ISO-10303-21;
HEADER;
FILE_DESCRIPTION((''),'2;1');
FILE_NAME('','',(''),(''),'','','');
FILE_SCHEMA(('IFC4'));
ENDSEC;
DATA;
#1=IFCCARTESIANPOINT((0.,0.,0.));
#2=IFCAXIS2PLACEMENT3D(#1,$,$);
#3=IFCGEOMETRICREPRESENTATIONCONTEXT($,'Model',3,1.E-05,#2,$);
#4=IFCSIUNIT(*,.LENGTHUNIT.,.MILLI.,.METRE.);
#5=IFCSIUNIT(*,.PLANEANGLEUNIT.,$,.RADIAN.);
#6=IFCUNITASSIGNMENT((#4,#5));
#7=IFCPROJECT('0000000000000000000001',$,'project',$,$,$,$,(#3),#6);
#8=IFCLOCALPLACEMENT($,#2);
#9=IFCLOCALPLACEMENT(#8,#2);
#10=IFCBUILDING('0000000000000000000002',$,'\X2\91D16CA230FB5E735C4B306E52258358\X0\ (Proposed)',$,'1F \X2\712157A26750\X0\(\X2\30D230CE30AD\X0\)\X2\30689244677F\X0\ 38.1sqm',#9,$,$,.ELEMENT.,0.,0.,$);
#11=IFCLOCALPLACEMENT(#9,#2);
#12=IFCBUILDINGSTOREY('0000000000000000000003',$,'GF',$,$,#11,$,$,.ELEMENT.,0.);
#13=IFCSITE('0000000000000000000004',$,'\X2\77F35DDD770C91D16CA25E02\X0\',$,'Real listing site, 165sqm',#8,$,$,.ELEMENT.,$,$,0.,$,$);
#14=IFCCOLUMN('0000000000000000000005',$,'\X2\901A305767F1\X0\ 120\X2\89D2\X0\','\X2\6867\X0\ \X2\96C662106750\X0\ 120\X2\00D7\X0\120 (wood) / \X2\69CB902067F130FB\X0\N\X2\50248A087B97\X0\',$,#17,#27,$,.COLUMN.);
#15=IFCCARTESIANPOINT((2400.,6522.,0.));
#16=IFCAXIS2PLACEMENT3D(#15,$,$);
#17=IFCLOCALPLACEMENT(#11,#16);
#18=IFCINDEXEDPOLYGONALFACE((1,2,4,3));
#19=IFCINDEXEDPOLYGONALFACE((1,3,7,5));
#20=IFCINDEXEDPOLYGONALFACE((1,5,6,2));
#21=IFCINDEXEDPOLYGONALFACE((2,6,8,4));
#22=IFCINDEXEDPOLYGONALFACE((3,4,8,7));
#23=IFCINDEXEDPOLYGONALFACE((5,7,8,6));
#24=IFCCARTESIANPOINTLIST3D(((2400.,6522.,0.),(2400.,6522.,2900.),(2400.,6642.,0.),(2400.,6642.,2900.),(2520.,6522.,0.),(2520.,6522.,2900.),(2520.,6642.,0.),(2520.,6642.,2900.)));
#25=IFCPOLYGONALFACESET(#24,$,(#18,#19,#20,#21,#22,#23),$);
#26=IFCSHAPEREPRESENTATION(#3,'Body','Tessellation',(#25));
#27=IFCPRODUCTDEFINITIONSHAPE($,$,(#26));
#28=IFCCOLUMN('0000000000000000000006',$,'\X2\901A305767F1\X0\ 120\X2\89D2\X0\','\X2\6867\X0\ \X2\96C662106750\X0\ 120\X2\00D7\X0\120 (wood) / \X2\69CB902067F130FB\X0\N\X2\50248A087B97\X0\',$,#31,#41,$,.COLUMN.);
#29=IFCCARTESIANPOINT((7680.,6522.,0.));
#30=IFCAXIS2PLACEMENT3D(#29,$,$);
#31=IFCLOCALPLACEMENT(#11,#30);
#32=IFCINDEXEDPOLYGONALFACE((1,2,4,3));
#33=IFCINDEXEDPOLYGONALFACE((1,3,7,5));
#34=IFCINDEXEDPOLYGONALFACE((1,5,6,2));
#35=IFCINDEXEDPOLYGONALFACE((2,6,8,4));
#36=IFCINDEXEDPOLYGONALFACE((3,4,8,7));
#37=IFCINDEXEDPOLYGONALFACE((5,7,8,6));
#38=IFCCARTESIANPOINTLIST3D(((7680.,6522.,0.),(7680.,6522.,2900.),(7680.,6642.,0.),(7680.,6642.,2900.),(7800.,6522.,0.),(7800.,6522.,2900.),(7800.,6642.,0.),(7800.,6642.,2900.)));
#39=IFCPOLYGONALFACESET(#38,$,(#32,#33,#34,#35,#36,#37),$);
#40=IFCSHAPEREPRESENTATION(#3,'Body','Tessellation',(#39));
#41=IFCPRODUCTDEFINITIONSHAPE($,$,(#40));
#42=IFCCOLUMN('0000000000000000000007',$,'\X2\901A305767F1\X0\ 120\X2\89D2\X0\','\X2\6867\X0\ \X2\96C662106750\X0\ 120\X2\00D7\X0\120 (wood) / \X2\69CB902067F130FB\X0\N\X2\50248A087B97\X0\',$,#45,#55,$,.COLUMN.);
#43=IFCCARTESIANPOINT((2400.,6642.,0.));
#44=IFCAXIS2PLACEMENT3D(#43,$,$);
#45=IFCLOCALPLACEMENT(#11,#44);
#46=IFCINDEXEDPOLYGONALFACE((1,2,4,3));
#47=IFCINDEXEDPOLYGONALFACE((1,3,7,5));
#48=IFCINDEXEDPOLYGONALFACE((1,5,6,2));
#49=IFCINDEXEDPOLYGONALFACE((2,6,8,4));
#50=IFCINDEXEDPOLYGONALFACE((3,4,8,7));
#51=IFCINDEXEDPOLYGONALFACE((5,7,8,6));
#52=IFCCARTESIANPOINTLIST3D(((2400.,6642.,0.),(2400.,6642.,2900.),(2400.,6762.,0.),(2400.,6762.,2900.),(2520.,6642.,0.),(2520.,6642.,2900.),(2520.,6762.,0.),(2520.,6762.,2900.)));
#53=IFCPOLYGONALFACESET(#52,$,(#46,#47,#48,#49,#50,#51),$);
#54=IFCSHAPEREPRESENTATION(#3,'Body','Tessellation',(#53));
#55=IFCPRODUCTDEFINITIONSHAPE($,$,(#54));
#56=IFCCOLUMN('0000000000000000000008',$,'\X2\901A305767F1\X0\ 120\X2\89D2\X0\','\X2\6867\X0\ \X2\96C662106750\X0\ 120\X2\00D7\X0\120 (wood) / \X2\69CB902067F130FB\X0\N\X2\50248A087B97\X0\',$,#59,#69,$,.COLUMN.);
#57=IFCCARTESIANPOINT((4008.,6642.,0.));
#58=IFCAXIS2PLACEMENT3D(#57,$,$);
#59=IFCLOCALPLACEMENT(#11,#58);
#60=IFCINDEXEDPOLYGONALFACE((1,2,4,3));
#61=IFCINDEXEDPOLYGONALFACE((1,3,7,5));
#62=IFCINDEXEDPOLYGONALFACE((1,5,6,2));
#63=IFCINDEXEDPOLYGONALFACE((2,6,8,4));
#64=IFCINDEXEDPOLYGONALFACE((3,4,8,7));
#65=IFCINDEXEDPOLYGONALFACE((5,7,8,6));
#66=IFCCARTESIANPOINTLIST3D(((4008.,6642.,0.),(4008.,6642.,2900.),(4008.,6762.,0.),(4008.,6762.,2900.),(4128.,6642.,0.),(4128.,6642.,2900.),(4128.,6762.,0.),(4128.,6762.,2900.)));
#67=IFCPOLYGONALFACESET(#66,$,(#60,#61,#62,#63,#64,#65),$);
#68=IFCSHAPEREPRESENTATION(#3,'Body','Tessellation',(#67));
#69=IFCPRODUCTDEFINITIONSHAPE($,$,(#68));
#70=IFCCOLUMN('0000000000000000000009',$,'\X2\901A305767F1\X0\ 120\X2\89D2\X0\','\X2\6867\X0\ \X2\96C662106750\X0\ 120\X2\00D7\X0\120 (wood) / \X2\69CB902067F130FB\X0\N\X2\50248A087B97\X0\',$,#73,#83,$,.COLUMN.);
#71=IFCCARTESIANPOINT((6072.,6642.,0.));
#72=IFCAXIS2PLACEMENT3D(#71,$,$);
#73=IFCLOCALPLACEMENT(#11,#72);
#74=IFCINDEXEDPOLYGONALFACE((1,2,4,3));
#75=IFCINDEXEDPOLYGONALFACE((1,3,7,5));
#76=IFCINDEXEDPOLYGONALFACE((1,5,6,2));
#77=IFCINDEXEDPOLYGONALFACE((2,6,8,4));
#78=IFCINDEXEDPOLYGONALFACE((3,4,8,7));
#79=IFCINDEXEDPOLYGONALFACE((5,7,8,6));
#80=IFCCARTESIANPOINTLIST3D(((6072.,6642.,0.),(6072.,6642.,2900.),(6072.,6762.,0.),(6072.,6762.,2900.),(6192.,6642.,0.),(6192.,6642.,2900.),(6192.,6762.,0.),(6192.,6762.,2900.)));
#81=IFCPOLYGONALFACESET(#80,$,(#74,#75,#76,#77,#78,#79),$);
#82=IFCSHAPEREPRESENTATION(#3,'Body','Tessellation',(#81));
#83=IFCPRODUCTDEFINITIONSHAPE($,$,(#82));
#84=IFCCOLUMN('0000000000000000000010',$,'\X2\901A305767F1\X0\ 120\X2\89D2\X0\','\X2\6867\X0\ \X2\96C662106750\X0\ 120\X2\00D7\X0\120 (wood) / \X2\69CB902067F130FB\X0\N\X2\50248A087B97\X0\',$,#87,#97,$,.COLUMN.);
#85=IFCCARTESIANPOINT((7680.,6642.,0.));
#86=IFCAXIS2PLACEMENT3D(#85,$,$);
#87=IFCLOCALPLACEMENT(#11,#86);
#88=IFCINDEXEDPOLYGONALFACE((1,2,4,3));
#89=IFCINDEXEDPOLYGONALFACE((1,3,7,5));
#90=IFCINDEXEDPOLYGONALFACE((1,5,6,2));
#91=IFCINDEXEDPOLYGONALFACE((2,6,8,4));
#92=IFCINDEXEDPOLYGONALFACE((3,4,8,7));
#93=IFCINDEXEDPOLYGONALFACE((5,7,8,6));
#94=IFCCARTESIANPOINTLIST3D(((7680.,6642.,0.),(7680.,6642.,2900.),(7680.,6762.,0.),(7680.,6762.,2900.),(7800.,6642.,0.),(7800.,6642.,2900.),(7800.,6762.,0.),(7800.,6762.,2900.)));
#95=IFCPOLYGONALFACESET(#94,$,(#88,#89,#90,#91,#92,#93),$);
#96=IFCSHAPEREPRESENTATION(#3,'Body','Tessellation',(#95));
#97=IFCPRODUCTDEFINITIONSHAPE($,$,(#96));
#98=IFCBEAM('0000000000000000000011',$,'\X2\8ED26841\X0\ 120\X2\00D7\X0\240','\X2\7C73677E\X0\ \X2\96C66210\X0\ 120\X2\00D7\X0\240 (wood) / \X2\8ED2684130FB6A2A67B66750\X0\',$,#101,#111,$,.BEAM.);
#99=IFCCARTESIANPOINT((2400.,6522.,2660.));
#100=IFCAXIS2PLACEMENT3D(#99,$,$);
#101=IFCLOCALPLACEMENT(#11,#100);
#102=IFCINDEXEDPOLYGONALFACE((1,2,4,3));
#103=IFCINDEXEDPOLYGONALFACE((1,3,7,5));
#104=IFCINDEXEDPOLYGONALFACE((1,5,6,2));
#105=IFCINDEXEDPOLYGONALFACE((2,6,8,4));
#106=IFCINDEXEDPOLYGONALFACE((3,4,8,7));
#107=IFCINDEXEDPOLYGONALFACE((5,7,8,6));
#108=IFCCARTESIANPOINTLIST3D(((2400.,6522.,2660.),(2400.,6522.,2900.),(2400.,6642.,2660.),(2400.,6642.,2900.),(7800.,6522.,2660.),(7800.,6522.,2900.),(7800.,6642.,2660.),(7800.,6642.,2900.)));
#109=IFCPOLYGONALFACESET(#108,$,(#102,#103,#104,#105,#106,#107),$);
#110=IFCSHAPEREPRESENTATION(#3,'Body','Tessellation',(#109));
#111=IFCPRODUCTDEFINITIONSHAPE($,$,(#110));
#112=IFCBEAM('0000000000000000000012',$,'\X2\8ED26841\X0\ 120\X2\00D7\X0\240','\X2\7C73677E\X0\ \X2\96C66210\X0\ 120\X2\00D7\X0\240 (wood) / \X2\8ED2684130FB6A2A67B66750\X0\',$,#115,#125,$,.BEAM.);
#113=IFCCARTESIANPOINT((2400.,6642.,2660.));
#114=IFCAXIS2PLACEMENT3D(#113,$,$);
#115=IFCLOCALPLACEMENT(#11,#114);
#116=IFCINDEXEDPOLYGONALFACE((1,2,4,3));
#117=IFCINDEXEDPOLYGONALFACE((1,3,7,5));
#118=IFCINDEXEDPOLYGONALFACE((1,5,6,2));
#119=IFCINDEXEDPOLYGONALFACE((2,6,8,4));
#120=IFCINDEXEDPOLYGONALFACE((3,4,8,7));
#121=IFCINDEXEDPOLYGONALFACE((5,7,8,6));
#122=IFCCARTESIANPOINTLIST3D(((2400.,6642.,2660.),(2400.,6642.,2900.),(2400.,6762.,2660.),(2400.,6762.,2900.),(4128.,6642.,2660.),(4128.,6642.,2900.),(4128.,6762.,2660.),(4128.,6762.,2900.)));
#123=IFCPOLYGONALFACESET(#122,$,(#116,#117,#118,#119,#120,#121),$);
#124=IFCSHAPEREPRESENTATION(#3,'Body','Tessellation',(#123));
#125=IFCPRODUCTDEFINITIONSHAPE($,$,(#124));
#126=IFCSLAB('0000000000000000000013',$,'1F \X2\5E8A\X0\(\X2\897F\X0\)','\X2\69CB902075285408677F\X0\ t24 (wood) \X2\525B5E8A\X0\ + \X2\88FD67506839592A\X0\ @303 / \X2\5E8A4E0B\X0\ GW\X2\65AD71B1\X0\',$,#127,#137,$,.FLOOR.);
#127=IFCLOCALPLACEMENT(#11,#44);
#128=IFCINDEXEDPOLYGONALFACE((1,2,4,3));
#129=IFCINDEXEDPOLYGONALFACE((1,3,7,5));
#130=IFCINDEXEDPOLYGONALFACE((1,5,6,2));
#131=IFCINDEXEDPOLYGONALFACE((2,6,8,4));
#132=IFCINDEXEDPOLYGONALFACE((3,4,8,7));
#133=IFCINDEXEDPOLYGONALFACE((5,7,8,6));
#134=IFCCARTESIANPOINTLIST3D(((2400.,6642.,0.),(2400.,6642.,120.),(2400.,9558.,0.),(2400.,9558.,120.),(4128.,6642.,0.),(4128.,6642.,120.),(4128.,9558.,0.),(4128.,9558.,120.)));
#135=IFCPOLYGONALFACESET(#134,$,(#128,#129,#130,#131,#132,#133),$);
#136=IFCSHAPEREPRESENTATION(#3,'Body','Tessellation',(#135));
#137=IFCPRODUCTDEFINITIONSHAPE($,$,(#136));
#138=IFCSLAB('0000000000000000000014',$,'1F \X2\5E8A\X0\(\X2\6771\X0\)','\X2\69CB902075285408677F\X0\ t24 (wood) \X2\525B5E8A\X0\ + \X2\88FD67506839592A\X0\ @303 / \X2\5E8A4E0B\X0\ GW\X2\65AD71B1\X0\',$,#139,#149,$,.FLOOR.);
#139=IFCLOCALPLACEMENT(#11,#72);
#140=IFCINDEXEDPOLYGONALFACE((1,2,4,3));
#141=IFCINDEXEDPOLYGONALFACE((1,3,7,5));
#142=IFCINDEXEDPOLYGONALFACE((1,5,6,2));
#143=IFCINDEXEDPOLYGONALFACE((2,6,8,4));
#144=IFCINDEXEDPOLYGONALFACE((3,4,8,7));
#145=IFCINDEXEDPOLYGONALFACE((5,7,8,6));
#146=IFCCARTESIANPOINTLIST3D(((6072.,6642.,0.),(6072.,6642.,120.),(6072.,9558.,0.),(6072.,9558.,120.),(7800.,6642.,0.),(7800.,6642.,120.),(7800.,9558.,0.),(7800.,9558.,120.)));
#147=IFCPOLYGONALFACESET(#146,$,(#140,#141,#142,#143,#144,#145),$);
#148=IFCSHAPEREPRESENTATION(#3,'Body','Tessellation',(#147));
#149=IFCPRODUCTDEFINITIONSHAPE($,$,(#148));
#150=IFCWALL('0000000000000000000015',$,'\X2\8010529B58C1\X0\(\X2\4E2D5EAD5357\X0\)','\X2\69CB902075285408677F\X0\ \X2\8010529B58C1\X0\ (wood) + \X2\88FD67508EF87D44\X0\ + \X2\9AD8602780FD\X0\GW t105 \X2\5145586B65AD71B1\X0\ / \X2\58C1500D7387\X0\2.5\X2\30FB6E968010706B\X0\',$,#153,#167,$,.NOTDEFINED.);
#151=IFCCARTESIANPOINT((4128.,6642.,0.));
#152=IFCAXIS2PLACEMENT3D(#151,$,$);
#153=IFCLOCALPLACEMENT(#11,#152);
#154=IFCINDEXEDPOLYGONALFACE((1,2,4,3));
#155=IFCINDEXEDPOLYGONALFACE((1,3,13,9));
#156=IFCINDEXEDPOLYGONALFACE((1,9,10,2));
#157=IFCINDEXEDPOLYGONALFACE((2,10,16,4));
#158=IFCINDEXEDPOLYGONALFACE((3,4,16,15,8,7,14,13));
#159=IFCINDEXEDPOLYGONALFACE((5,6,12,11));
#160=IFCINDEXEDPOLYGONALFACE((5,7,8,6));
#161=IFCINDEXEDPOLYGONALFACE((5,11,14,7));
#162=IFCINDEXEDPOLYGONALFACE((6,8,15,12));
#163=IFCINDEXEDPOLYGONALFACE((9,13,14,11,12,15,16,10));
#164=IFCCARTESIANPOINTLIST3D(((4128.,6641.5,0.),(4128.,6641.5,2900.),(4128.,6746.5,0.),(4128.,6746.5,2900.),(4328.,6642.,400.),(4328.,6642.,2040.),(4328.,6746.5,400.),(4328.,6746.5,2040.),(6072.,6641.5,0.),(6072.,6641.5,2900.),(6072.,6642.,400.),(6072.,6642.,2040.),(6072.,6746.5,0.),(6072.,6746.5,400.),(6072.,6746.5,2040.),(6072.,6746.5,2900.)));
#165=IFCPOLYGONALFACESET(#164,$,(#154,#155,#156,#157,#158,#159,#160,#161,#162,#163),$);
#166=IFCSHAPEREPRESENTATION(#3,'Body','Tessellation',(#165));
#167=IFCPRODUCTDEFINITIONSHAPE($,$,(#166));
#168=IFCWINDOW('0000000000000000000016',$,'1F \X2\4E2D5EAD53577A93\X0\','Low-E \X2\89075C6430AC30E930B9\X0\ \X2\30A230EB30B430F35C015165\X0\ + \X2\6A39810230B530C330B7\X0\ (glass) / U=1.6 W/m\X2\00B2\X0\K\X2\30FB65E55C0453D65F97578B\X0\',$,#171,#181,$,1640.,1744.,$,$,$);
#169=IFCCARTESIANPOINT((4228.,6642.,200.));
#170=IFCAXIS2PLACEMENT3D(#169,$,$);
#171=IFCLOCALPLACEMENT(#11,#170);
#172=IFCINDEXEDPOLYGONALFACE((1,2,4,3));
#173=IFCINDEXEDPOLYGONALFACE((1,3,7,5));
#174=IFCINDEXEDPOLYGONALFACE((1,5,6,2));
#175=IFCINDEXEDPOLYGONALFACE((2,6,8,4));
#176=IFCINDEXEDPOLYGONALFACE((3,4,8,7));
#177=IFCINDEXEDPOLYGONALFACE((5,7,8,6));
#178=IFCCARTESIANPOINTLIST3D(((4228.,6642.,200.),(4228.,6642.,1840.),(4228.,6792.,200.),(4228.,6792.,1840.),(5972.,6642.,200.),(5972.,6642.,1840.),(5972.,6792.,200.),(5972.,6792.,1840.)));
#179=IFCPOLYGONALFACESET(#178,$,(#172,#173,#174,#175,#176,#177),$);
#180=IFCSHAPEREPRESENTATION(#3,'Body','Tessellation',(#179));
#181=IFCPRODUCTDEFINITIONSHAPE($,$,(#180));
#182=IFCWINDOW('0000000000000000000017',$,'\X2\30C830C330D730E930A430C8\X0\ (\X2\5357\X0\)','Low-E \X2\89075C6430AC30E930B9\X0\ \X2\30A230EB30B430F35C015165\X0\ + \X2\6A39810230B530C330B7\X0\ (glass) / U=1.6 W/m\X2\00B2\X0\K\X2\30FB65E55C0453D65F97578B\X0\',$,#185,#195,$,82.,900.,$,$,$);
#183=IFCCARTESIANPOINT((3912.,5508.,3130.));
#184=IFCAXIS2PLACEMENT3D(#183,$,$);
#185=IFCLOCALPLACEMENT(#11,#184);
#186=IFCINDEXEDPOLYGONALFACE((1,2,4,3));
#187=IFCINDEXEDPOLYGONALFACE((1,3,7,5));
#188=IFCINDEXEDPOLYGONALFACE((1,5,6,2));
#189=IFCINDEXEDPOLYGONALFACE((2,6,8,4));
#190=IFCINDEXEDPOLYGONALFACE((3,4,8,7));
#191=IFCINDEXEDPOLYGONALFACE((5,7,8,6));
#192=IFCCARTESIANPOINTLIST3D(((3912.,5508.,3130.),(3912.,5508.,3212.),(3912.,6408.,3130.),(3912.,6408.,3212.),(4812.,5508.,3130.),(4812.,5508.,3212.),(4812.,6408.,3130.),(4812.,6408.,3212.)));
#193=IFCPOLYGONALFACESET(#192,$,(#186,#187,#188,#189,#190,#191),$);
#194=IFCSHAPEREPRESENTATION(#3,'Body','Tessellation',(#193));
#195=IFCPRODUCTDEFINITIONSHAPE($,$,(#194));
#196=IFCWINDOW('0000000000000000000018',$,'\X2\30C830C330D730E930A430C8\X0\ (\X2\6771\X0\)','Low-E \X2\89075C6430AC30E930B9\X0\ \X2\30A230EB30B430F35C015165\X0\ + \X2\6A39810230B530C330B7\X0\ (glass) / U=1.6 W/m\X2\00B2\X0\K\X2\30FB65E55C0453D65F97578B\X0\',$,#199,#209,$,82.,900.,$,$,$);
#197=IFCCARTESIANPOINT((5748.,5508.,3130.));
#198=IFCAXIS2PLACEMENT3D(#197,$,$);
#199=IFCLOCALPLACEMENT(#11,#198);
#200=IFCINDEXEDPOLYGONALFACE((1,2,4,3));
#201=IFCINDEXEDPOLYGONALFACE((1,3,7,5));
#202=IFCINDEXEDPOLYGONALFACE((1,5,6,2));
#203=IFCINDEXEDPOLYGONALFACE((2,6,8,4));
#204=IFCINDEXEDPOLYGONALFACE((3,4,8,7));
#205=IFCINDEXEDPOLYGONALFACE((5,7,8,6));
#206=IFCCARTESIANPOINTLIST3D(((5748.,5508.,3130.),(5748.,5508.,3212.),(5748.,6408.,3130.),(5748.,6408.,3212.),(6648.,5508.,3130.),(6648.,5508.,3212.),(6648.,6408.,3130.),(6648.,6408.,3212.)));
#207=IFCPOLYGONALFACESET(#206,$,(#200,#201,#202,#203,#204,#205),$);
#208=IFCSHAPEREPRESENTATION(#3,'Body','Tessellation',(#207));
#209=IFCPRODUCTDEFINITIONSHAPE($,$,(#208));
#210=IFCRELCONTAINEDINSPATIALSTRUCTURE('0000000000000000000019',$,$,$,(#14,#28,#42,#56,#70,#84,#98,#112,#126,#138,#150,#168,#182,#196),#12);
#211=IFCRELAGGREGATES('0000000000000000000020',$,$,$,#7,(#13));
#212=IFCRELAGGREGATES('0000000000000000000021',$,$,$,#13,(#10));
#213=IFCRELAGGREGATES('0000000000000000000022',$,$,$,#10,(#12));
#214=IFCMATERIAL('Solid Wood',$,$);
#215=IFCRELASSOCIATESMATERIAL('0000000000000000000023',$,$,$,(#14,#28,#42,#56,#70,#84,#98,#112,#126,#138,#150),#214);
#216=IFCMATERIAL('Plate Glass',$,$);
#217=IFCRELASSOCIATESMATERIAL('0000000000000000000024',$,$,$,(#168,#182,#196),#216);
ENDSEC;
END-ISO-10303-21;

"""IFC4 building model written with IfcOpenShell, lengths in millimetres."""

from ifc_helpers import new_model, si_unit, frame, frame_2d, origin, place, context, project, spatial, rectangle, extrude, material, element, fill, save


model = new_model("IFC4")

# Units and contexts
model_context = context("Model", 3, precision=1e-05, world=origin())
ifc_project = project(units=[si_unit("LENGTHUNIT", "METRE", prefix="MILLI"), si_unit("PLANEANGLEUNIT", "RADIAN")], contexts=[model_context])

# Site, building, storey
site_placement = place(None, origin())
site = spatial("IfcSite", under=ifc_project, at=site_placement, Name="石川県金沢市", ObjectType="Real listing site, 165sqm", CompositionType="ELEMENT", RefElevation=0.0)
building_placement = place(site_placement, origin())
building = spatial("IfcBuilding", under=site, at=building_placement, Name="金沢・平屋の別荘 (Proposed)", ObjectType="1F 無垢材(ヒノキ)と鉄板 38.1sqm", CompositionType="ELEMENT", ElevationOfRefHeight=0.0, ElevationOfTerrain=0.0)
storey_placement = place(building_placement, origin())
storey = spatial("IfcBuildingStorey", under=building, at=storey_placement, Name="GF", CompositionType="ELEMENT", Elevation=0.0)

# Columns
ifc_material_1 = material(Name="Solid Wood")
column_1_placement = place(storey_placement, frame((2400.0, 6522.0, 0.0)))
element("IfcColumn", 1, at=column_1_placement, inside=storey, material=ifc_material_1, Name="通し柱 120角", Description="桧 集成材 120×120 (wood) / 構造柱・N値計算", PredefinedType="COLUMN", context=model_context, shape_type="SweptSolid", body=[
    extrude(rectangle(XDim=120.0, YDim=120.0, at=frame_2d((60.0, 60.0))), frame((2400.0, 6522.0, 0.0)), (0.0, 0.0, 1.0), 2900.0),
])
column_2_placement = place(storey_placement, frame((7680.0, 6522.0, 0.0)))
element("IfcColumn", 2, at=column_2_placement, inside=storey, material=ifc_material_1, Name="通し柱 120角", Description="桧 集成材 120×120 (wood) / 構造柱・N値計算", PredefinedType="COLUMN", context=model_context, shape_type="SweptSolid", body=[
    extrude(rectangle(XDim=120.0, YDim=120.0, at=frame_2d((60.0, 60.0))), frame((7680.0, 6522.0, 0.0)), (0.0, 0.0, 1.0), 2900.0),
])
column_3_placement = place(storey_placement, frame((2400.0, 6642.0, 0.0)))
element("IfcColumn", 3, at=column_3_placement, inside=storey, material=ifc_material_1, Name="通し柱 120角", Description="桧 集成材 120×120 (wood) / 構造柱・N値計算", PredefinedType="COLUMN", context=model_context, shape_type="SweptSolid", body=[
    extrude(rectangle(XDim=120.0, YDim=120.0, at=frame_2d((60.0, 60.0))), frame((2400.0, 6642.0, 0.0)), (0.0, 0.0, 1.0), 2900.0),
])
column_4_placement = place(storey_placement, frame((4008.0, 6642.0, 0.0)))
element("IfcColumn", 4, at=column_4_placement, inside=storey, material=ifc_material_1, Name="通し柱 120角", Description="桧 集成材 120×120 (wood) / 構造柱・N値計算", PredefinedType="COLUMN", context=model_context, shape_type="SweptSolid", body=[
    extrude(rectangle(XDim=120.0, YDim=120.0, at=frame_2d((60.0, 60.0))), frame((4008.0, 6642.0, 0.0)), (0.0, 0.0, 1.0), 2900.0),
])
column_5_placement = place(storey_placement, frame((6072.0, 6642.0, 0.0)))
element("IfcColumn", 5, at=column_5_placement, inside=storey, material=ifc_material_1, Name="通し柱 120角", Description="桧 集成材 120×120 (wood) / 構造柱・N値計算", PredefinedType="COLUMN", context=model_context, shape_type="SweptSolid", body=[
    extrude(rectangle(XDim=120.0, YDim=120.0, at=frame_2d((60.0, 60.0))), frame((6072.0, 6642.0, 0.0)), (0.0, 0.0, 1.0), 2900.0),
])
column_6_placement = place(storey_placement, frame((7680.0, 6642.0, 0.0)))
element("IfcColumn", 6, at=column_6_placement, inside=storey, material=ifc_material_1, Name="通し柱 120角", Description="桧 集成材 120×120 (wood) / 構造柱・N値計算", PredefinedType="COLUMN", context=model_context, shape_type="SweptSolid", body=[
    extrude(rectangle(XDim=120.0, YDim=120.0, at=frame_2d((60.0, 60.0))), frame((7680.0, 6642.0, 0.0)), (0.0, 0.0, 1.0), 2900.0),
])

# Beams
beam_1_placement = place(storey_placement, frame((2400.0, 6522.0, 2660.0)))
element("IfcBeam", 7, at=beam_1_placement, inside=storey, material=ifc_material_1, Name="軒桁 120×240", Description="米松 集成 120×240 (wood) / 軒桁・横架材", PredefinedType="BEAM", context=model_context, shape_type="SweptSolid", body=[
    extrude(rectangle(XDim=5400.0, YDim=120.0, at=frame_2d((2700.0, 60.0))), frame((2400.0, 6522.0, 2660.0)), (0.0, 0.0, 1.0), 240.0),
])
beam_2_placement = place(storey_placement, frame((2400.0, 6642.0, 2660.0)))
element("IfcBeam", 8, at=beam_2_placement, inside=storey, material=ifc_material_1, Name="軒桁 120×240", Description="米松 集成 120×240 (wood) / 軒桁・横架材", PredefinedType="BEAM", context=model_context, shape_type="SweptSolid", body=[
    extrude(rectangle(XDim=1728.0, YDim=120.0, at=frame_2d((864.0, 60.0))), frame((2400.0, 6642.0, 2660.0)), (0.0, 0.0, 1.0), 240.0),
])

# Slabs
slab_1_placement = place(storey_placement, frame((2400.0, 6642.0, 0.0)))
element("IfcSlab", 9, at=slab_1_placement, inside=storey, material=ifc_material_1, Name="1F 床(西)", Description="構造用合板 t24 (wood) 剛床 + 製材根太 @303 / 床下 GW断熱", PredefinedType="FLOOR", context=model_context, shape_type="SweptSolid", body=[
    extrude(rectangle(XDim=1728.0, YDim=2916.0, at=frame_2d((864.0, 1458.0))), frame((2400.0, 6642.0, 0.0)), (0.0, 0.0, 1.0), 120.0),
])
slab_2_placement = place(storey_placement, frame((6072.0, 6642.0, 0.0)))
element("IfcSlab", 10, at=slab_2_placement, inside=storey, material=ifc_material_1, Name="1F 床(東)", Description="構造用合板 t24 (wood) 剛床 + 製材根太 @303 / 床下 GW断熱", PredefinedType="FLOOR", context=model_context, shape_type="SweptSolid", body=[
    extrude(rectangle(XDim=1728.0, YDim=2916.0, at=frame_2d((864.0, 1458.0))), frame((6072.0, 6642.0, 0.0)), (0.0, 0.0, 1.0), 120.0),
])

# Wall, opening, window
wall_1_placement = place(storey_placement, frame((4128.0, 6642.0, 0.0)))
wall_1 = element("IfcWall", 11, at=wall_1_placement, inside=storey, material=ifc_material_1, Name="耐力壁(中庭南)", Description="構造用合板 耐力壁 (wood) + 製材軸組 + 高性能GW t105 充填断熱 / 壁倍率2.5・準耐火", PredefinedType="NOTDEFINED", context=model_context, shape_type="SweptSolid", body=[
    extrude(rectangle(XDim=1944.0, YDim=105.0, at=frame_2d((972.0, 52.0))), frame((4128.0, 6642.0, 0.0)), (0.0, 0.0, 1.0), 2900.0),
])
opening_placement = place(storey_placement, frame((4228.0, 6642.0, 200.0)))
opening = element("IfcOpeningElement", 12, at=opening_placement, cuts=wall_1, PredefinedType="NOTDEFINED", context=model_context, shape_type="SweptSolid", body=[
    extrude(rectangle(XDim=1744.0, YDim=150.0, at=frame_2d((872.0, 75.0))), frame((4228.0, 6642.0, 200.0)), (0.0, 0.0, 1.0), 1640.0),
])
ifc_material_2 = material(Name="Plate Glass")
window_1_placement = place(storey_placement, frame((4228.0, 6642.0, 200.0)))
window_1 = element("IfcWindow", 13, at=window_1_placement, inside=storey, material=ifc_material_2, Name="1F 中庭南窓", Description="Low-E 複層ガラス アルゴン封入 + 樹脂サッシ (glass) / U=1.6 W/m²K・日射取得型", OverallHeight=1640.0, OverallWidth=1744.0, context=model_context, shape_type="SweptSolid", body=[
    extrude(rectangle(XDim=1744.0, YDim=150.0, at=frame_2d((872.0, 75.0))), frame((4228.0, 6642.0, 200.0)), (0.0, 0.0, 1.0), 1640.0),
])
fill(opening, window_1)

# Windows
window_2_placement = place(storey_placement, frame((3912.0, 5508.0, 3130.0)))
element("IfcWindow", 14, at=window_2_placement, inside=storey, material=ifc_material_2, Name="トップライト (南)", Description="Low-E 複層ガラス アルゴン封入 + 樹脂サッシ (glass) / U=1.6 W/m²K・日射取得型", OverallHeight=82.0, OverallWidth=900.0, context=model_context, shape_type="SweptSolid", body=[
    extrude(rectangle(XDim=900.0, YDim=900.0, at=frame_2d((450.0, 450.0))), frame((3912.0, 5508.0, 3130.0)), (0.0, 0.0, 1.0), 82.0),
])
window_3_placement = place(storey_placement, frame((5748.0, 5508.0, 3130.0)))
element("IfcWindow", 15, at=window_3_placement, inside=storey, material=ifc_material_2, Name="トップライト (東)", Description="Low-E 複層ガラス アルゴン封入 + 樹脂サッシ (glass) / U=1.6 W/m²K・日射取得型", OverallHeight=82.0, OverallWidth=900.0, context=model_context, shape_type="SweptSolid", body=[
    extrude(rectangle(XDim=900.0, YDim=900.0, at=frame_2d((450.0, 450.0))), frame((5748.0, 5508.0, 3130.0)), (0.0, 0.0, 1.0), 82.0),
])

save(model, "model.ifc")
